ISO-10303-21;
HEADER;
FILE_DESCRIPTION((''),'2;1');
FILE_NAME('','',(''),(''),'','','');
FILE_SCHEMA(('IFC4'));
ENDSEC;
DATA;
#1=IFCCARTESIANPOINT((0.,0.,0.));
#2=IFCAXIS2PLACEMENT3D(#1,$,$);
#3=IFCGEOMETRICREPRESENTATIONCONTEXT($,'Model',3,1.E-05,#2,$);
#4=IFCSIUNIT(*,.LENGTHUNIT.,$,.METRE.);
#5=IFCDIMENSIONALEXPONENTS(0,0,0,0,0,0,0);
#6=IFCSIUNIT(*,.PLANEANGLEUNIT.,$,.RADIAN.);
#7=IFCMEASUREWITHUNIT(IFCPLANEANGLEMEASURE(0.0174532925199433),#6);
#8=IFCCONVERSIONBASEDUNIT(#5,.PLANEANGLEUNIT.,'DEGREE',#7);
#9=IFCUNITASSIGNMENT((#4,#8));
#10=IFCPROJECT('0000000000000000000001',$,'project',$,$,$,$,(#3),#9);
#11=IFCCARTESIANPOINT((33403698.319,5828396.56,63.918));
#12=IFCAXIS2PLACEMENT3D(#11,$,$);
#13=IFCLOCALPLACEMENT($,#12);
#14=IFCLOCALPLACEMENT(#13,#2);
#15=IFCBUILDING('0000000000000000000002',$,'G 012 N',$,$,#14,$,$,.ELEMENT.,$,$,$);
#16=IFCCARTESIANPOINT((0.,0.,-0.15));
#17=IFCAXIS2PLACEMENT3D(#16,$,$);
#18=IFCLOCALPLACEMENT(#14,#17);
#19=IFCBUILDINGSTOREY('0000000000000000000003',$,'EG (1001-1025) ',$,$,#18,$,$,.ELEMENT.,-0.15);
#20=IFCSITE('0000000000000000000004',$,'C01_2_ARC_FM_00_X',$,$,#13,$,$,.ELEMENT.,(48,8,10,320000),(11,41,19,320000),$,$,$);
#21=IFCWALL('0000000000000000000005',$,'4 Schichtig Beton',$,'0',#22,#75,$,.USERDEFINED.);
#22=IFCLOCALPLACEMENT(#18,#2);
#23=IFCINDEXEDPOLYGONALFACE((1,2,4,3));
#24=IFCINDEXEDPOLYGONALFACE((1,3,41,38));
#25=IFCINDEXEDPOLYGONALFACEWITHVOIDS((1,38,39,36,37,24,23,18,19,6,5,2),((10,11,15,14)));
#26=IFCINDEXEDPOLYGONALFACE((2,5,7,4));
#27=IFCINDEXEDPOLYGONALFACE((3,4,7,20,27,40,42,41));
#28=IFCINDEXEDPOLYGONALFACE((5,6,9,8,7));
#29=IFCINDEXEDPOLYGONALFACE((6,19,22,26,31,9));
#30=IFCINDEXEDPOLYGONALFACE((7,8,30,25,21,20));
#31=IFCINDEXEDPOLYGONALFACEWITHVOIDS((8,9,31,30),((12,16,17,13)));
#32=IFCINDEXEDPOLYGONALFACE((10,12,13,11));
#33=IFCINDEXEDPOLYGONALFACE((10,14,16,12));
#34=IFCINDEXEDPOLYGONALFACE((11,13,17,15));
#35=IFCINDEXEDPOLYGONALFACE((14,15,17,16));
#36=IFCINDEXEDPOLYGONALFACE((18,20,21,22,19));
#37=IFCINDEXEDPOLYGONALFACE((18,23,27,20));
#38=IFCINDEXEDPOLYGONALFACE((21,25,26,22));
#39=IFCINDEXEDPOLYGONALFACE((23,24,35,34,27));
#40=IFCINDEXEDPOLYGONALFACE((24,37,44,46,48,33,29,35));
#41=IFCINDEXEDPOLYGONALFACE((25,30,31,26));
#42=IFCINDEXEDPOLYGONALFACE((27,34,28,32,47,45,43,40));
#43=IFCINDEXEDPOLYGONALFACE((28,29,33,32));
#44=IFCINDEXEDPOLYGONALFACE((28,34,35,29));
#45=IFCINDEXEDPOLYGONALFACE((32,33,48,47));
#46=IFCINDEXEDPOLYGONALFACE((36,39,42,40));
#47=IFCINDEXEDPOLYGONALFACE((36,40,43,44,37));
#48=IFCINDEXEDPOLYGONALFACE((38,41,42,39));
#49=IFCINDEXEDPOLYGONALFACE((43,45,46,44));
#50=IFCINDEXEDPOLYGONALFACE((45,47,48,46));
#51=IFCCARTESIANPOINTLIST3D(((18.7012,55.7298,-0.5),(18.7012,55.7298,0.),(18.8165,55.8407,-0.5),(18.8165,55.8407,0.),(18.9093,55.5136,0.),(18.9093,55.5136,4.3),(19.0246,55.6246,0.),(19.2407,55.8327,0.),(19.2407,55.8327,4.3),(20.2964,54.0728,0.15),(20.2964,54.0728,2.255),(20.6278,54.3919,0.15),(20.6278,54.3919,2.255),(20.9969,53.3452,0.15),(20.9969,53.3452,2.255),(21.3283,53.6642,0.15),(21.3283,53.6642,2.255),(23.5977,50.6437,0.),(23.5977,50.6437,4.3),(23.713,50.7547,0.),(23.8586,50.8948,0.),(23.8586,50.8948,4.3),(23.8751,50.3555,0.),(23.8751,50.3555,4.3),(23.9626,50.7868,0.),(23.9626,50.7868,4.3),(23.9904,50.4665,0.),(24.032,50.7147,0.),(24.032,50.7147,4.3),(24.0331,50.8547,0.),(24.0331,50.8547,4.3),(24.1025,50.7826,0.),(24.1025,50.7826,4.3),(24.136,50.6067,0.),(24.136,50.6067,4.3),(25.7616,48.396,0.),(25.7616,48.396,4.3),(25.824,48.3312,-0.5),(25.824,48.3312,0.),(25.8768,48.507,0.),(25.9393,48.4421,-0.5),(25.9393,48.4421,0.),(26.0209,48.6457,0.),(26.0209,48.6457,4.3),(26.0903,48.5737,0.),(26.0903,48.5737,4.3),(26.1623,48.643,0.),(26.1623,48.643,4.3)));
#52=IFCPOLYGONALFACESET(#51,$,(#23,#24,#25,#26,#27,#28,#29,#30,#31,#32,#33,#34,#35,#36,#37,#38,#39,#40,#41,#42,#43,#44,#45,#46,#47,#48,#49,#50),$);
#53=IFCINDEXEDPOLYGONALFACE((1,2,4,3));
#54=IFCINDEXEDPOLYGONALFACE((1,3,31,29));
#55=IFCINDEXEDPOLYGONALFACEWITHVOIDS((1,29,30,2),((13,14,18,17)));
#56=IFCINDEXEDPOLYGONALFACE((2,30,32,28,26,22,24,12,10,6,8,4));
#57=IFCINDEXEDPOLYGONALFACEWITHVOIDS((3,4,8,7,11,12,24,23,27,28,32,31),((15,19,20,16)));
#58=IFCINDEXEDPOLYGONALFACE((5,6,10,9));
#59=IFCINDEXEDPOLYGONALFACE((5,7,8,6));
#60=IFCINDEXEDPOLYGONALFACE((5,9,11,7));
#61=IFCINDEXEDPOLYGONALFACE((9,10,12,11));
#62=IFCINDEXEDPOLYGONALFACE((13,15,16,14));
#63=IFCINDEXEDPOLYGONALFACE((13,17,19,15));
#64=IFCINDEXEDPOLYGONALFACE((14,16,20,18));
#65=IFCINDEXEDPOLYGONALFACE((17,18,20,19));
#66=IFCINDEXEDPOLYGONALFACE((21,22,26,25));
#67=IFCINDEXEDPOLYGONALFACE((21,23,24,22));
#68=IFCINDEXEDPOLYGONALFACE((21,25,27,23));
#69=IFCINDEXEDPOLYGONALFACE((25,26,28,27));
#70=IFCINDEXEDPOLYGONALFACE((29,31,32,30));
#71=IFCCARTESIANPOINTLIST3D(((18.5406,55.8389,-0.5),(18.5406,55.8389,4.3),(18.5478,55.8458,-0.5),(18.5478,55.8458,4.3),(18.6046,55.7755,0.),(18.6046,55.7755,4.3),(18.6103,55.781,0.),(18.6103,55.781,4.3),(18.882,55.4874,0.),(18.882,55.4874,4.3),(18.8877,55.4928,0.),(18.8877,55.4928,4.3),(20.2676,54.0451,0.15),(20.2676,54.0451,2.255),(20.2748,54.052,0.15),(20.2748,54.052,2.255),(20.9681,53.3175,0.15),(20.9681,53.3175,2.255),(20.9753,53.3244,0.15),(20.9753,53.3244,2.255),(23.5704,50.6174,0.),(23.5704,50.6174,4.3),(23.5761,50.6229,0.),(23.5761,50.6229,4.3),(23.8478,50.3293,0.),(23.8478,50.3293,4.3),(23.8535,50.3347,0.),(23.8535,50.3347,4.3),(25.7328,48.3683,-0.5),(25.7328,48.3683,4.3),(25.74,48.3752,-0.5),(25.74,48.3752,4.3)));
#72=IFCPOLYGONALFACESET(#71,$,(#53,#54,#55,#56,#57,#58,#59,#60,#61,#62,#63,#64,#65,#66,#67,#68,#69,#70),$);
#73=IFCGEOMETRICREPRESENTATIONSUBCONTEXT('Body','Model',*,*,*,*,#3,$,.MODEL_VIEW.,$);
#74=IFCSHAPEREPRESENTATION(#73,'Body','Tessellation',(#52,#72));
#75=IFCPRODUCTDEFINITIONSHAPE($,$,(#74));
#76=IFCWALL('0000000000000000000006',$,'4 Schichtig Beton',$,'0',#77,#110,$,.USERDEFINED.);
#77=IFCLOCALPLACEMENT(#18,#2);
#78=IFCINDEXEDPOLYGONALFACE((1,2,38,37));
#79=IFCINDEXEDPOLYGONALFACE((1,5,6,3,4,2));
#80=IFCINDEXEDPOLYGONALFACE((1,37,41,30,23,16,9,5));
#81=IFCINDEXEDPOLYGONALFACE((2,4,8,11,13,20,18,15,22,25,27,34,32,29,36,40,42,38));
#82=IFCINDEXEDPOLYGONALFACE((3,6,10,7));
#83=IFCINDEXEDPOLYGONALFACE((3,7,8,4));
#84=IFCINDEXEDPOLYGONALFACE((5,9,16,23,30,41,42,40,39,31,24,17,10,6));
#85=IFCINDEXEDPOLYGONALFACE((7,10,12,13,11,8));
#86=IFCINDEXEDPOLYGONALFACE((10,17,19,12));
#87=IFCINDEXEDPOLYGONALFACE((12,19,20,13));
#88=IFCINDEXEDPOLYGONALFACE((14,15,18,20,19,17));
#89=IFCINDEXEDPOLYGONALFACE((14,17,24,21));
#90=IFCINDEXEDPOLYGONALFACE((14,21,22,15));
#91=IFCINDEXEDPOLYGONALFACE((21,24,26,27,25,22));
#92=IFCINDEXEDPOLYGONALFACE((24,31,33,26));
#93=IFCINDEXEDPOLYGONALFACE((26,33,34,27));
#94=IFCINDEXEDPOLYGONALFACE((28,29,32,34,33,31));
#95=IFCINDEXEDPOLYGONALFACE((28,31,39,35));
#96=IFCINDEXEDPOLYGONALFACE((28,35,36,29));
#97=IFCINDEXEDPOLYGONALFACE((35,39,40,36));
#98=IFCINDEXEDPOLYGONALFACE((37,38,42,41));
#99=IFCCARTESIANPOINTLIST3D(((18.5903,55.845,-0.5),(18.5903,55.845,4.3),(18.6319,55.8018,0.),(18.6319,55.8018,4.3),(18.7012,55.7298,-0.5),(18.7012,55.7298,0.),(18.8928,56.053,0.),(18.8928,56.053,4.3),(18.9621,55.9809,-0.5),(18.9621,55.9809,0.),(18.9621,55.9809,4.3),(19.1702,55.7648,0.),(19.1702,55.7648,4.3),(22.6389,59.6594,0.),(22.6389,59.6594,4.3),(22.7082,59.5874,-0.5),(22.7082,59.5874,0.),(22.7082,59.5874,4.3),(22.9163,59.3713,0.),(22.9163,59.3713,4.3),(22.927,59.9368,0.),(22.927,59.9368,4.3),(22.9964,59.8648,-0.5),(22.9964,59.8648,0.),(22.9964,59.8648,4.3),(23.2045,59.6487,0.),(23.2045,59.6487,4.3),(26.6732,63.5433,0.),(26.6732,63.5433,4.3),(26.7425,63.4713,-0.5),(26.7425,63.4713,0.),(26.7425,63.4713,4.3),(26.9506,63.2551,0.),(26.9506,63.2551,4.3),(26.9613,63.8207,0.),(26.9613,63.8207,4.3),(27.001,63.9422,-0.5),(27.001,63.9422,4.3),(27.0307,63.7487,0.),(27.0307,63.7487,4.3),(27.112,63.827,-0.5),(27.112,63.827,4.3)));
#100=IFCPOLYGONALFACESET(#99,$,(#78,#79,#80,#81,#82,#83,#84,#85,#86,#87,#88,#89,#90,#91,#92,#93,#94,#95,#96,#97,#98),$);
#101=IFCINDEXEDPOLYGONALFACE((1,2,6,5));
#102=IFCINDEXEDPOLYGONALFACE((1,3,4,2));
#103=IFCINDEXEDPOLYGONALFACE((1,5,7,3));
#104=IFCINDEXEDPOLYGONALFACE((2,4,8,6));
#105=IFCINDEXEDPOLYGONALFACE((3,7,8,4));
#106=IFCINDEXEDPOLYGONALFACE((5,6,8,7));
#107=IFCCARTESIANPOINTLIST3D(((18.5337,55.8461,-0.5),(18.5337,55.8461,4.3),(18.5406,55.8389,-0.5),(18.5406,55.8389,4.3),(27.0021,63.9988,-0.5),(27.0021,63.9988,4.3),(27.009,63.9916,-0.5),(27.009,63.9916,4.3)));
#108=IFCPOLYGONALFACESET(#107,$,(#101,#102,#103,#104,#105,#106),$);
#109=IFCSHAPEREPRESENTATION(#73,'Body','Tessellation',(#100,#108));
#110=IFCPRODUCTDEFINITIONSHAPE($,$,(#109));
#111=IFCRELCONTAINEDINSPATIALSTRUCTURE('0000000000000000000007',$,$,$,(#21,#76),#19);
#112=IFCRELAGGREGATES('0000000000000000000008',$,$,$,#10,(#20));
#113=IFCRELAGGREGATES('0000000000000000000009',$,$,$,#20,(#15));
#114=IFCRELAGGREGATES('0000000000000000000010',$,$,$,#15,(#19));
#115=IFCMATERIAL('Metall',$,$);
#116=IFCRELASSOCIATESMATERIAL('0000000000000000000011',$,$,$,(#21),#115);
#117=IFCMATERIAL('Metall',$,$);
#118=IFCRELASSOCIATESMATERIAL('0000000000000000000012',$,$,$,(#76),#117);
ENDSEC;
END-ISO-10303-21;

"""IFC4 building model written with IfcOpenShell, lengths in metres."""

from ifc_helpers import new_model, entity, si_unit, converted_unit, frame, frame_2d, origin, origin_with_axes, place, context, subcontext, project, spatial, polyline, rectangle, outline, extrude, clip, bounded_halfspace, material, element, save


model = new_model("IFC4")

# Units and contexts
model_context = context("Model", 3, precision=1e-05, world=origin())
body_context = subcontext(model_context, "Body", "Model", "MODEL_VIEW")
ifc_project = project(units=[si_unit("LENGTHUNIT", "METRE"), converted_unit("PLANEANGLEUNIT", "DEGREE", entity("IfcPlaneAngleMeasure", 0.0174532925199433), si_unit("PLANEANGLEUNIT", "RADIAN"), dimensions=[0, 0, 0, 0, 0, 0, 0])], contexts=[model_context])

# Site, building, storey
site_placement = place(None, frame((33403698.319, 5828396.56, 63.918)))
site = spatial("IfcSite", under=ifc_project, at=site_placement, Name="C01_2_ARC_FM_00_X", CompositionType="ELEMENT", RefLatitude=(48, 8, 10, 320000), RefLongitude=(11, 41, 19, 320000))
building_placement = place(site_placement, origin())
building = spatial("IfcBuilding", under=site, at=building_placement, Name="G 012 N", CompositionType="ELEMENT")
storey_placement = place(building_placement, frame((0.0, 0.0, -0.15)))
storey = spatial("IfcBuildingStorey", under=building, at=storey_placement, Name="EG (1001-1025) ", CompositionType="ELEMENT", Elevation=-0.15)

# Wall, opening
ifc_material_1 = material(Name="Metall")
wall_1_placement = place(storey_placement, frame((18.5406, 55.8389, -0.5), z_axis=(0.0, 0.0, 1.0), x_axis=(0.693551, -0.720408, 0.0)))
wall_1 = element("IfcWall", 1, at=wall_1_placement, inside=storey, material=ifc_material_1, Name="4 Schichtig Beton", ObjectType="0", PredefinedType="USERDEFINED", context=body_context, shape_type="Clipping", body=[
    clip(clip(clip(clip(clip(clip(clip(extrude(outline(polyline([(4.94, 5.2913), (4.85, 5.2913), (4.85, 5.4913), (4.95, 5.4913), (4.95, 5.5913), (1.98, 5.5913), (1.98, 5.4934), (2.13, 5.4934), (2.13, 5.2913), (1.73, 5.2913), (1.73, 5.4934), (1.88, 5.4934), (1.88, 5.5913), (-5.03, 5.5913), (-5.03, 5.2913), (-5.33, 5.2913), (-5.33, 5.1313), (4.94, 5.1313), (4.94, 5.2913)])), frame((5.52, -5.0913, 0.0), z_axis=(0.0, 0.0, 1.0), x_axis=(1.0, 0.0, 0.0)), (0.0, 0.0, 1.0), 4.8), bounded_halfspace(frame((5.0467, 0.3674, 0.5), z_axis=(0.0, 0.0, 1.0), x_axis=(1.0, 0.0, 0.0)), True, origin_with_axes(), polyline([(0.49, 0.2), (7.25, 0.2), (7.25, 0.4021), (7.4, 0.4021), (7.4, 0.5), (0.49, 0.5), (0.49, 0.2)]))), bounded_halfspace(frame((8.9975, 0.3755, 0.5), z_axis=(0.0, 0.0, 1.0), x_axis=(1.0, 0.0, 0.0)), True, origin_with_axes(), polyline([(7.65, 0.2), (10.37, 0.2), (10.37, 0.4), (10.47, 0.4), (10.47, 0.5), (7.5, 0.5), (7.5, 0.4021), (7.65, 0.4021), (7.65, 0.2)]))), bounded_halfspace(frame((7.45, 0.0061, 0.5), z_axis=(0.0, 0.0, -1.0), x_axis=(1.0, 0.0, 0.0)), True, origin_with_axes(), polyline([(7.25, 0.0021), (7.65, 0.0021), (7.65, 0.01), (7.25, 0.01), (7.25, 0.0021)]))), bounded_halfspace(frame((0.29, 0.0061, 0.5), z_axis=(0.0, 0.0, -1.0), x_axis=(1.0, 0.0, 0.0)), True, origin_with_axes(), polyline([(0.09, 0.0021), (0.49, 0.0021), (0.49, 0.01), (0.09, 0.01), (0.09, 0.0021)]))), bounded_halfspace(frame((10.415, 0.12, 0.5), z_axis=(0.0, 0.0, -1.0), x_axis=(0.0, 1.0, 0.0)), True, origin_with_axes(), polyline([(10.46, 0.04), (10.46, 0.2), (10.37, 0.2), (10.37, 0.04), (10.46, 0.04)]))), bounded_halfspace(frame((0.34, 0.12, 0.5), z_axis=(0.0, 0.0, -1.0), x_axis=(0.0, -1.0, 0.0)), True, origin_with_axes(), polyline([(0.19, 0.2), (0.19, 0.04), (0.49, 0.04), (0.49, 0.2), (0.19, 0.2)]))), bounded_halfspace(frame((7.45, 0.12, 0.5), z_axis=(0.0, 0.0, -1.0), x_axis=(0.0, -1.0, 0.0)), True, origin_with_axes(), polyline([(7.25, 0.2), (7.25, 0.04), (7.65, 0.04), (7.65, 0.2), (7.25, 0.2)]))),
    clip(clip(clip(clip(clip(clip(clip(extrude(rectangle(XDim=10.37, YDim=0.01, at=frame_2d((-5.185, -0.005), x_axis=(-1.0, 0.0))), frame((10.37, 0.01, 0.0), z_axis=(0.0, 0.0, 1.0), x_axis=(1.0, 0.0, 0.0)), (0.0, 0.0, 1.0), 4.8), bounded_halfspace(frame((5.0467, 0.3674, 0.5), z_axis=(0.0, 0.0, 1.0), x_axis=(1.0, 0.0, 0.0)), True, origin_with_axes(), polyline([(0.49, 0.2), (7.25, 0.2), (7.25, 0.4021), (7.4, 0.4021), (7.4, 0.5), (0.49, 0.5), (0.49, 0.2)]))), bounded_halfspace(frame((8.9975, 0.3755, 0.5), z_axis=(0.0, 0.0, 1.0), x_axis=(1.0, 0.0, 0.0)), True, origin_with_axes(), polyline([(7.65, 0.2), (10.37, 0.2), (10.37, 0.4), (10.47, 0.4), (10.47, 0.5), (7.5, 0.5), (7.5, 0.4021), (7.65, 0.4021), (7.65, 0.2)]))), bounded_halfspace(frame((7.45, 0.0061, 0.5), z_axis=(0.0, 0.0, -1.0), x_axis=(1.0, 0.0, 0.0)), True, origin_with_axes(), polyline([(7.25, 0.0021), (7.65, 0.0021), (7.65, 0.01), (7.25, 0.01), (7.25, 0.0021)]))), bounded_halfspace(frame((0.29, 0.0061, 0.5), z_axis=(0.0, 0.0, -1.0), x_axis=(1.0, 0.0, 0.0)), True, origin_with_axes(), polyline([(0.09, 0.0021), (0.49, 0.0021), (0.49, 0.01), (0.09, 0.01), (0.09, 0.0021)]))), bounded_halfspace(frame((10.415, 0.12, 0.5), z_axis=(0.0, 0.0, -1.0), x_axis=(0.0, 1.0, 0.0)), True, origin_with_axes(), polyline([(10.46, 0.04), (10.46, 0.2), (10.37, 0.2), (10.37, 0.04), (10.46, 0.04)]))), bounded_halfspace(frame((0.34, 0.12, 0.5), z_axis=(0.0, 0.0, -1.0), x_axis=(0.0, -1.0, 0.0)), True, origin_with_axes(), polyline([(0.19, 0.2), (0.19, 0.04), (0.49, 0.04), (0.49, 0.2), (0.19, 0.2)]))), bounded_halfspace(frame((7.45, 0.12, 0.5), z_axis=(0.0, 0.0, -1.0), x_axis=(0.0, -1.0, 0.0)), True, origin_with_axes(), polyline([(7.25, 0.2), (7.25, 0.04), (7.65, 0.04), (7.65, 0.2), (7.25, 0.2)]))),
])
opening_1_placement = place(wall_1_placement, frame((3.5, 0.01, 0.65), z_axis=(0.0, -1.0, 0.0), x_axis=(0.0, 0.0, 1.0)))
element("IfcOpeningElement", 2, at=opening_1_placement, cuts=wall_1, ObjectType="Opening", context=body_context, shape_type="SweptSolid", body=[
    extrude(outline(polyline([(0.0, 1.01), (2.105, 1.01), (2.105, 0.0), (0.0, 0.0), (0.0, 1.01)])), origin_with_axes(), (0.0, 0.0, 1.0), 0.01),
    extrude(outline(polyline([(0.0, 1.01), (2.105, 1.01), (2.105, 0.0), (0.0, 0.0), (0.0, 1.01)])), frame((0.0, 0.0, -0.03), z_axis=(0.0, 0.0, 1.0), x_axis=(1.0, 0.0, 0.0)), (0.0, 0.0, 1.0), 0.03),
    extrude(outline(polyline([(0.0, 1.01), (2.105, 1.01), (2.105, 0.0), (0.0, 0.0), (0.0, 1.01)])), frame((0.0, 0.0, -0.19), z_axis=(0.0, 0.0, 1.0), x_axis=(1.0, 0.0, 0.0)), (0.0, 0.0, 1.0), 0.16),
    extrude(outline(polyline([(0.0, 1.01), (2.105, 1.01), (2.105, 0.0), (0.0, 0.0), (0.0, 1.01)])), frame((0.0, 0.0, -0.49), z_axis=(0.0, 0.0, 1.0), x_axis=(1.0, 0.0, 0.0)), (0.0, 0.0, 1.0), 0.3),
])

# Wall
ifc_material_2 = material(Name="Metall")
wall_2_placement = place(storey_placement, frame((27.0021, 63.9988, -0.5), z_axis=(0.0, 0.0, 1.0), x_axis=(-0.720408, -0.693551, 0.0)))
element("IfcWall", 3, at=wall_2_placement, inside=storey, material=ifc_material_2, Name="4 Schichtig Beton", ObjectType="0", PredefinedType="USERDEFINED", context=body_context, shape_type="Clipping", body=[
    clip(clip(clip(clip(clip(extrude(outline(polyline([(-0.4421, 0.077), (-0.4421, 0.377), (-5.6421, 0.377), (-5.6421, 0.077), (-6.0421, 0.077), (-6.0421, 0.377), (-11.2421, 0.377), (-11.2421, 0.077), (-11.7549, 0.077), (-11.7549, -0.083), (-0.0799, -0.083), (-0.0799, 0.077), (-0.4421, 0.077)])), frame((11.7949, 0.123, 0.0), z_axis=(0.0, 0.0, 1.0), x_axis=(1.0, 0.0, 0.0)), (0.0, 0.0, 1.0), 4.8), bounded_halfspace(frame((3.1529, 0.35, 0.5), z_axis=(0.0, 0.0, 1.0), x_axis=(1.0, 0.0, 0.0)), True, origin_with_axes(), polyline([(0.5529, 0.2), (5.7529, 0.2), (5.7529, 0.5), (0.5529, 0.5), (0.5529, 0.2)]))), bounded_halfspace(frame((8.7529, 0.35, 0.5), z_axis=(0.0, 0.0, 1.0), x_axis=(0.0, 1.0, 0.0)), True, origin_with_axes(), polyline([(11.3529, 0.2), (11.3529, 0.5), (6.1529, 0.5), (6.1529, 0.2), (11.3529, 0.2)]))), bounded_halfspace(frame((0.3529, 0.15, 0.5), z_axis=(0.0, 0.0, -1.0), x_axis=(0.0, 1.0, 0.0)), True, origin_with_axes(), polyline([(0.5529, 0.1), (0.5529, 0.2), (0.1529, 0.2), (0.1529, 0.1), (0.5529, 0.1)]))), bounded_halfspace(frame((11.5339, 0.15, 0.5), z_axis=(0.0, 0.0, -1.0), x_axis=(0.0, 1.0, 0.0)), True, origin_with_axes(), polyline([(11.715, 0.1), (11.715, 0.2), (11.3529, 0.2), (11.3529, 0.1), (11.715, 0.1)]))), bounded_halfspace(frame((5.9529, 0.15, 0.5), z_axis=(0.0, 0.0, -1.0), x_axis=(0.0, 1.0, 0.0)), True, origin_with_axes(), polyline([(6.1529, 0.1), (6.1529, 0.2), (5.7529, 0.2), (5.7529, 0.1), (6.1529, 0.1)]))),
    clip(clip(clip(clip(clip(extrude(rectangle(XDim=11.755, YDim=0.01, at=frame_2d((-5.8775, -0.005), x_axis=(-1.0, 0.0))), frame((11.755, 0.01, 0.0), z_axis=(0.0, 0.0, 1.0), x_axis=(1.0, 0.0, 0.0)), (0.0, 0.0, 1.0), 4.8), bounded_halfspace(frame((3.1529, 0.35, 0.5), z_axis=(0.0, 0.0, 1.0), x_axis=(1.0, 0.0, 0.0)), True, origin_with_axes(), polyline([(0.5529, 0.2), (5.7529, 0.2), (5.7529, 0.5), (0.5529, 0.5), (0.5529, 0.2)]))), bounded_halfspace(frame((8.7529, 0.35, 0.5), z_axis=(0.0, 0.0, 1.0), x_axis=(0.0, 1.0, 0.0)), True, origin_with_axes(), polyline([(11.3529, 0.2), (11.3529, 0.5), (6.1529, 0.5), (6.1529, 0.2), (11.3529, 0.2)]))), bounded_halfspace(frame((0.3529, 0.15, 0.5), z_axis=(0.0, 0.0, -1.0), x_axis=(0.0, 1.0, 0.0)), True, origin_with_axes(), polyline([(0.5529, 0.1), (0.5529, 0.2), (0.1529, 0.2), (0.1529, 0.1), (0.5529, 0.1)]))), bounded_halfspace(frame((11.5339, 0.15, 0.5), z_axis=(0.0, 0.0, -1.0), x_axis=(0.0, 1.0, 0.0)), True, origin_with_axes(), polyline([(11.715, 0.1), (11.715, 0.2), (11.3529, 0.2), (11.3529, 0.1), (11.715, 0.1)]))), bounded_halfspace(frame((5.9529, 0.15, 0.5), z_axis=(0.0, 0.0, -1.0), x_axis=(0.0, 1.0, 0.0)), True, origin_with_axes(), polyline([(6.1529, 0.1), (6.1529, 0.2), (5.7529, 0.2), (5.7529, 0.1), (6.1529, 0.1)]))),
])

save(model, "model.ifc")
